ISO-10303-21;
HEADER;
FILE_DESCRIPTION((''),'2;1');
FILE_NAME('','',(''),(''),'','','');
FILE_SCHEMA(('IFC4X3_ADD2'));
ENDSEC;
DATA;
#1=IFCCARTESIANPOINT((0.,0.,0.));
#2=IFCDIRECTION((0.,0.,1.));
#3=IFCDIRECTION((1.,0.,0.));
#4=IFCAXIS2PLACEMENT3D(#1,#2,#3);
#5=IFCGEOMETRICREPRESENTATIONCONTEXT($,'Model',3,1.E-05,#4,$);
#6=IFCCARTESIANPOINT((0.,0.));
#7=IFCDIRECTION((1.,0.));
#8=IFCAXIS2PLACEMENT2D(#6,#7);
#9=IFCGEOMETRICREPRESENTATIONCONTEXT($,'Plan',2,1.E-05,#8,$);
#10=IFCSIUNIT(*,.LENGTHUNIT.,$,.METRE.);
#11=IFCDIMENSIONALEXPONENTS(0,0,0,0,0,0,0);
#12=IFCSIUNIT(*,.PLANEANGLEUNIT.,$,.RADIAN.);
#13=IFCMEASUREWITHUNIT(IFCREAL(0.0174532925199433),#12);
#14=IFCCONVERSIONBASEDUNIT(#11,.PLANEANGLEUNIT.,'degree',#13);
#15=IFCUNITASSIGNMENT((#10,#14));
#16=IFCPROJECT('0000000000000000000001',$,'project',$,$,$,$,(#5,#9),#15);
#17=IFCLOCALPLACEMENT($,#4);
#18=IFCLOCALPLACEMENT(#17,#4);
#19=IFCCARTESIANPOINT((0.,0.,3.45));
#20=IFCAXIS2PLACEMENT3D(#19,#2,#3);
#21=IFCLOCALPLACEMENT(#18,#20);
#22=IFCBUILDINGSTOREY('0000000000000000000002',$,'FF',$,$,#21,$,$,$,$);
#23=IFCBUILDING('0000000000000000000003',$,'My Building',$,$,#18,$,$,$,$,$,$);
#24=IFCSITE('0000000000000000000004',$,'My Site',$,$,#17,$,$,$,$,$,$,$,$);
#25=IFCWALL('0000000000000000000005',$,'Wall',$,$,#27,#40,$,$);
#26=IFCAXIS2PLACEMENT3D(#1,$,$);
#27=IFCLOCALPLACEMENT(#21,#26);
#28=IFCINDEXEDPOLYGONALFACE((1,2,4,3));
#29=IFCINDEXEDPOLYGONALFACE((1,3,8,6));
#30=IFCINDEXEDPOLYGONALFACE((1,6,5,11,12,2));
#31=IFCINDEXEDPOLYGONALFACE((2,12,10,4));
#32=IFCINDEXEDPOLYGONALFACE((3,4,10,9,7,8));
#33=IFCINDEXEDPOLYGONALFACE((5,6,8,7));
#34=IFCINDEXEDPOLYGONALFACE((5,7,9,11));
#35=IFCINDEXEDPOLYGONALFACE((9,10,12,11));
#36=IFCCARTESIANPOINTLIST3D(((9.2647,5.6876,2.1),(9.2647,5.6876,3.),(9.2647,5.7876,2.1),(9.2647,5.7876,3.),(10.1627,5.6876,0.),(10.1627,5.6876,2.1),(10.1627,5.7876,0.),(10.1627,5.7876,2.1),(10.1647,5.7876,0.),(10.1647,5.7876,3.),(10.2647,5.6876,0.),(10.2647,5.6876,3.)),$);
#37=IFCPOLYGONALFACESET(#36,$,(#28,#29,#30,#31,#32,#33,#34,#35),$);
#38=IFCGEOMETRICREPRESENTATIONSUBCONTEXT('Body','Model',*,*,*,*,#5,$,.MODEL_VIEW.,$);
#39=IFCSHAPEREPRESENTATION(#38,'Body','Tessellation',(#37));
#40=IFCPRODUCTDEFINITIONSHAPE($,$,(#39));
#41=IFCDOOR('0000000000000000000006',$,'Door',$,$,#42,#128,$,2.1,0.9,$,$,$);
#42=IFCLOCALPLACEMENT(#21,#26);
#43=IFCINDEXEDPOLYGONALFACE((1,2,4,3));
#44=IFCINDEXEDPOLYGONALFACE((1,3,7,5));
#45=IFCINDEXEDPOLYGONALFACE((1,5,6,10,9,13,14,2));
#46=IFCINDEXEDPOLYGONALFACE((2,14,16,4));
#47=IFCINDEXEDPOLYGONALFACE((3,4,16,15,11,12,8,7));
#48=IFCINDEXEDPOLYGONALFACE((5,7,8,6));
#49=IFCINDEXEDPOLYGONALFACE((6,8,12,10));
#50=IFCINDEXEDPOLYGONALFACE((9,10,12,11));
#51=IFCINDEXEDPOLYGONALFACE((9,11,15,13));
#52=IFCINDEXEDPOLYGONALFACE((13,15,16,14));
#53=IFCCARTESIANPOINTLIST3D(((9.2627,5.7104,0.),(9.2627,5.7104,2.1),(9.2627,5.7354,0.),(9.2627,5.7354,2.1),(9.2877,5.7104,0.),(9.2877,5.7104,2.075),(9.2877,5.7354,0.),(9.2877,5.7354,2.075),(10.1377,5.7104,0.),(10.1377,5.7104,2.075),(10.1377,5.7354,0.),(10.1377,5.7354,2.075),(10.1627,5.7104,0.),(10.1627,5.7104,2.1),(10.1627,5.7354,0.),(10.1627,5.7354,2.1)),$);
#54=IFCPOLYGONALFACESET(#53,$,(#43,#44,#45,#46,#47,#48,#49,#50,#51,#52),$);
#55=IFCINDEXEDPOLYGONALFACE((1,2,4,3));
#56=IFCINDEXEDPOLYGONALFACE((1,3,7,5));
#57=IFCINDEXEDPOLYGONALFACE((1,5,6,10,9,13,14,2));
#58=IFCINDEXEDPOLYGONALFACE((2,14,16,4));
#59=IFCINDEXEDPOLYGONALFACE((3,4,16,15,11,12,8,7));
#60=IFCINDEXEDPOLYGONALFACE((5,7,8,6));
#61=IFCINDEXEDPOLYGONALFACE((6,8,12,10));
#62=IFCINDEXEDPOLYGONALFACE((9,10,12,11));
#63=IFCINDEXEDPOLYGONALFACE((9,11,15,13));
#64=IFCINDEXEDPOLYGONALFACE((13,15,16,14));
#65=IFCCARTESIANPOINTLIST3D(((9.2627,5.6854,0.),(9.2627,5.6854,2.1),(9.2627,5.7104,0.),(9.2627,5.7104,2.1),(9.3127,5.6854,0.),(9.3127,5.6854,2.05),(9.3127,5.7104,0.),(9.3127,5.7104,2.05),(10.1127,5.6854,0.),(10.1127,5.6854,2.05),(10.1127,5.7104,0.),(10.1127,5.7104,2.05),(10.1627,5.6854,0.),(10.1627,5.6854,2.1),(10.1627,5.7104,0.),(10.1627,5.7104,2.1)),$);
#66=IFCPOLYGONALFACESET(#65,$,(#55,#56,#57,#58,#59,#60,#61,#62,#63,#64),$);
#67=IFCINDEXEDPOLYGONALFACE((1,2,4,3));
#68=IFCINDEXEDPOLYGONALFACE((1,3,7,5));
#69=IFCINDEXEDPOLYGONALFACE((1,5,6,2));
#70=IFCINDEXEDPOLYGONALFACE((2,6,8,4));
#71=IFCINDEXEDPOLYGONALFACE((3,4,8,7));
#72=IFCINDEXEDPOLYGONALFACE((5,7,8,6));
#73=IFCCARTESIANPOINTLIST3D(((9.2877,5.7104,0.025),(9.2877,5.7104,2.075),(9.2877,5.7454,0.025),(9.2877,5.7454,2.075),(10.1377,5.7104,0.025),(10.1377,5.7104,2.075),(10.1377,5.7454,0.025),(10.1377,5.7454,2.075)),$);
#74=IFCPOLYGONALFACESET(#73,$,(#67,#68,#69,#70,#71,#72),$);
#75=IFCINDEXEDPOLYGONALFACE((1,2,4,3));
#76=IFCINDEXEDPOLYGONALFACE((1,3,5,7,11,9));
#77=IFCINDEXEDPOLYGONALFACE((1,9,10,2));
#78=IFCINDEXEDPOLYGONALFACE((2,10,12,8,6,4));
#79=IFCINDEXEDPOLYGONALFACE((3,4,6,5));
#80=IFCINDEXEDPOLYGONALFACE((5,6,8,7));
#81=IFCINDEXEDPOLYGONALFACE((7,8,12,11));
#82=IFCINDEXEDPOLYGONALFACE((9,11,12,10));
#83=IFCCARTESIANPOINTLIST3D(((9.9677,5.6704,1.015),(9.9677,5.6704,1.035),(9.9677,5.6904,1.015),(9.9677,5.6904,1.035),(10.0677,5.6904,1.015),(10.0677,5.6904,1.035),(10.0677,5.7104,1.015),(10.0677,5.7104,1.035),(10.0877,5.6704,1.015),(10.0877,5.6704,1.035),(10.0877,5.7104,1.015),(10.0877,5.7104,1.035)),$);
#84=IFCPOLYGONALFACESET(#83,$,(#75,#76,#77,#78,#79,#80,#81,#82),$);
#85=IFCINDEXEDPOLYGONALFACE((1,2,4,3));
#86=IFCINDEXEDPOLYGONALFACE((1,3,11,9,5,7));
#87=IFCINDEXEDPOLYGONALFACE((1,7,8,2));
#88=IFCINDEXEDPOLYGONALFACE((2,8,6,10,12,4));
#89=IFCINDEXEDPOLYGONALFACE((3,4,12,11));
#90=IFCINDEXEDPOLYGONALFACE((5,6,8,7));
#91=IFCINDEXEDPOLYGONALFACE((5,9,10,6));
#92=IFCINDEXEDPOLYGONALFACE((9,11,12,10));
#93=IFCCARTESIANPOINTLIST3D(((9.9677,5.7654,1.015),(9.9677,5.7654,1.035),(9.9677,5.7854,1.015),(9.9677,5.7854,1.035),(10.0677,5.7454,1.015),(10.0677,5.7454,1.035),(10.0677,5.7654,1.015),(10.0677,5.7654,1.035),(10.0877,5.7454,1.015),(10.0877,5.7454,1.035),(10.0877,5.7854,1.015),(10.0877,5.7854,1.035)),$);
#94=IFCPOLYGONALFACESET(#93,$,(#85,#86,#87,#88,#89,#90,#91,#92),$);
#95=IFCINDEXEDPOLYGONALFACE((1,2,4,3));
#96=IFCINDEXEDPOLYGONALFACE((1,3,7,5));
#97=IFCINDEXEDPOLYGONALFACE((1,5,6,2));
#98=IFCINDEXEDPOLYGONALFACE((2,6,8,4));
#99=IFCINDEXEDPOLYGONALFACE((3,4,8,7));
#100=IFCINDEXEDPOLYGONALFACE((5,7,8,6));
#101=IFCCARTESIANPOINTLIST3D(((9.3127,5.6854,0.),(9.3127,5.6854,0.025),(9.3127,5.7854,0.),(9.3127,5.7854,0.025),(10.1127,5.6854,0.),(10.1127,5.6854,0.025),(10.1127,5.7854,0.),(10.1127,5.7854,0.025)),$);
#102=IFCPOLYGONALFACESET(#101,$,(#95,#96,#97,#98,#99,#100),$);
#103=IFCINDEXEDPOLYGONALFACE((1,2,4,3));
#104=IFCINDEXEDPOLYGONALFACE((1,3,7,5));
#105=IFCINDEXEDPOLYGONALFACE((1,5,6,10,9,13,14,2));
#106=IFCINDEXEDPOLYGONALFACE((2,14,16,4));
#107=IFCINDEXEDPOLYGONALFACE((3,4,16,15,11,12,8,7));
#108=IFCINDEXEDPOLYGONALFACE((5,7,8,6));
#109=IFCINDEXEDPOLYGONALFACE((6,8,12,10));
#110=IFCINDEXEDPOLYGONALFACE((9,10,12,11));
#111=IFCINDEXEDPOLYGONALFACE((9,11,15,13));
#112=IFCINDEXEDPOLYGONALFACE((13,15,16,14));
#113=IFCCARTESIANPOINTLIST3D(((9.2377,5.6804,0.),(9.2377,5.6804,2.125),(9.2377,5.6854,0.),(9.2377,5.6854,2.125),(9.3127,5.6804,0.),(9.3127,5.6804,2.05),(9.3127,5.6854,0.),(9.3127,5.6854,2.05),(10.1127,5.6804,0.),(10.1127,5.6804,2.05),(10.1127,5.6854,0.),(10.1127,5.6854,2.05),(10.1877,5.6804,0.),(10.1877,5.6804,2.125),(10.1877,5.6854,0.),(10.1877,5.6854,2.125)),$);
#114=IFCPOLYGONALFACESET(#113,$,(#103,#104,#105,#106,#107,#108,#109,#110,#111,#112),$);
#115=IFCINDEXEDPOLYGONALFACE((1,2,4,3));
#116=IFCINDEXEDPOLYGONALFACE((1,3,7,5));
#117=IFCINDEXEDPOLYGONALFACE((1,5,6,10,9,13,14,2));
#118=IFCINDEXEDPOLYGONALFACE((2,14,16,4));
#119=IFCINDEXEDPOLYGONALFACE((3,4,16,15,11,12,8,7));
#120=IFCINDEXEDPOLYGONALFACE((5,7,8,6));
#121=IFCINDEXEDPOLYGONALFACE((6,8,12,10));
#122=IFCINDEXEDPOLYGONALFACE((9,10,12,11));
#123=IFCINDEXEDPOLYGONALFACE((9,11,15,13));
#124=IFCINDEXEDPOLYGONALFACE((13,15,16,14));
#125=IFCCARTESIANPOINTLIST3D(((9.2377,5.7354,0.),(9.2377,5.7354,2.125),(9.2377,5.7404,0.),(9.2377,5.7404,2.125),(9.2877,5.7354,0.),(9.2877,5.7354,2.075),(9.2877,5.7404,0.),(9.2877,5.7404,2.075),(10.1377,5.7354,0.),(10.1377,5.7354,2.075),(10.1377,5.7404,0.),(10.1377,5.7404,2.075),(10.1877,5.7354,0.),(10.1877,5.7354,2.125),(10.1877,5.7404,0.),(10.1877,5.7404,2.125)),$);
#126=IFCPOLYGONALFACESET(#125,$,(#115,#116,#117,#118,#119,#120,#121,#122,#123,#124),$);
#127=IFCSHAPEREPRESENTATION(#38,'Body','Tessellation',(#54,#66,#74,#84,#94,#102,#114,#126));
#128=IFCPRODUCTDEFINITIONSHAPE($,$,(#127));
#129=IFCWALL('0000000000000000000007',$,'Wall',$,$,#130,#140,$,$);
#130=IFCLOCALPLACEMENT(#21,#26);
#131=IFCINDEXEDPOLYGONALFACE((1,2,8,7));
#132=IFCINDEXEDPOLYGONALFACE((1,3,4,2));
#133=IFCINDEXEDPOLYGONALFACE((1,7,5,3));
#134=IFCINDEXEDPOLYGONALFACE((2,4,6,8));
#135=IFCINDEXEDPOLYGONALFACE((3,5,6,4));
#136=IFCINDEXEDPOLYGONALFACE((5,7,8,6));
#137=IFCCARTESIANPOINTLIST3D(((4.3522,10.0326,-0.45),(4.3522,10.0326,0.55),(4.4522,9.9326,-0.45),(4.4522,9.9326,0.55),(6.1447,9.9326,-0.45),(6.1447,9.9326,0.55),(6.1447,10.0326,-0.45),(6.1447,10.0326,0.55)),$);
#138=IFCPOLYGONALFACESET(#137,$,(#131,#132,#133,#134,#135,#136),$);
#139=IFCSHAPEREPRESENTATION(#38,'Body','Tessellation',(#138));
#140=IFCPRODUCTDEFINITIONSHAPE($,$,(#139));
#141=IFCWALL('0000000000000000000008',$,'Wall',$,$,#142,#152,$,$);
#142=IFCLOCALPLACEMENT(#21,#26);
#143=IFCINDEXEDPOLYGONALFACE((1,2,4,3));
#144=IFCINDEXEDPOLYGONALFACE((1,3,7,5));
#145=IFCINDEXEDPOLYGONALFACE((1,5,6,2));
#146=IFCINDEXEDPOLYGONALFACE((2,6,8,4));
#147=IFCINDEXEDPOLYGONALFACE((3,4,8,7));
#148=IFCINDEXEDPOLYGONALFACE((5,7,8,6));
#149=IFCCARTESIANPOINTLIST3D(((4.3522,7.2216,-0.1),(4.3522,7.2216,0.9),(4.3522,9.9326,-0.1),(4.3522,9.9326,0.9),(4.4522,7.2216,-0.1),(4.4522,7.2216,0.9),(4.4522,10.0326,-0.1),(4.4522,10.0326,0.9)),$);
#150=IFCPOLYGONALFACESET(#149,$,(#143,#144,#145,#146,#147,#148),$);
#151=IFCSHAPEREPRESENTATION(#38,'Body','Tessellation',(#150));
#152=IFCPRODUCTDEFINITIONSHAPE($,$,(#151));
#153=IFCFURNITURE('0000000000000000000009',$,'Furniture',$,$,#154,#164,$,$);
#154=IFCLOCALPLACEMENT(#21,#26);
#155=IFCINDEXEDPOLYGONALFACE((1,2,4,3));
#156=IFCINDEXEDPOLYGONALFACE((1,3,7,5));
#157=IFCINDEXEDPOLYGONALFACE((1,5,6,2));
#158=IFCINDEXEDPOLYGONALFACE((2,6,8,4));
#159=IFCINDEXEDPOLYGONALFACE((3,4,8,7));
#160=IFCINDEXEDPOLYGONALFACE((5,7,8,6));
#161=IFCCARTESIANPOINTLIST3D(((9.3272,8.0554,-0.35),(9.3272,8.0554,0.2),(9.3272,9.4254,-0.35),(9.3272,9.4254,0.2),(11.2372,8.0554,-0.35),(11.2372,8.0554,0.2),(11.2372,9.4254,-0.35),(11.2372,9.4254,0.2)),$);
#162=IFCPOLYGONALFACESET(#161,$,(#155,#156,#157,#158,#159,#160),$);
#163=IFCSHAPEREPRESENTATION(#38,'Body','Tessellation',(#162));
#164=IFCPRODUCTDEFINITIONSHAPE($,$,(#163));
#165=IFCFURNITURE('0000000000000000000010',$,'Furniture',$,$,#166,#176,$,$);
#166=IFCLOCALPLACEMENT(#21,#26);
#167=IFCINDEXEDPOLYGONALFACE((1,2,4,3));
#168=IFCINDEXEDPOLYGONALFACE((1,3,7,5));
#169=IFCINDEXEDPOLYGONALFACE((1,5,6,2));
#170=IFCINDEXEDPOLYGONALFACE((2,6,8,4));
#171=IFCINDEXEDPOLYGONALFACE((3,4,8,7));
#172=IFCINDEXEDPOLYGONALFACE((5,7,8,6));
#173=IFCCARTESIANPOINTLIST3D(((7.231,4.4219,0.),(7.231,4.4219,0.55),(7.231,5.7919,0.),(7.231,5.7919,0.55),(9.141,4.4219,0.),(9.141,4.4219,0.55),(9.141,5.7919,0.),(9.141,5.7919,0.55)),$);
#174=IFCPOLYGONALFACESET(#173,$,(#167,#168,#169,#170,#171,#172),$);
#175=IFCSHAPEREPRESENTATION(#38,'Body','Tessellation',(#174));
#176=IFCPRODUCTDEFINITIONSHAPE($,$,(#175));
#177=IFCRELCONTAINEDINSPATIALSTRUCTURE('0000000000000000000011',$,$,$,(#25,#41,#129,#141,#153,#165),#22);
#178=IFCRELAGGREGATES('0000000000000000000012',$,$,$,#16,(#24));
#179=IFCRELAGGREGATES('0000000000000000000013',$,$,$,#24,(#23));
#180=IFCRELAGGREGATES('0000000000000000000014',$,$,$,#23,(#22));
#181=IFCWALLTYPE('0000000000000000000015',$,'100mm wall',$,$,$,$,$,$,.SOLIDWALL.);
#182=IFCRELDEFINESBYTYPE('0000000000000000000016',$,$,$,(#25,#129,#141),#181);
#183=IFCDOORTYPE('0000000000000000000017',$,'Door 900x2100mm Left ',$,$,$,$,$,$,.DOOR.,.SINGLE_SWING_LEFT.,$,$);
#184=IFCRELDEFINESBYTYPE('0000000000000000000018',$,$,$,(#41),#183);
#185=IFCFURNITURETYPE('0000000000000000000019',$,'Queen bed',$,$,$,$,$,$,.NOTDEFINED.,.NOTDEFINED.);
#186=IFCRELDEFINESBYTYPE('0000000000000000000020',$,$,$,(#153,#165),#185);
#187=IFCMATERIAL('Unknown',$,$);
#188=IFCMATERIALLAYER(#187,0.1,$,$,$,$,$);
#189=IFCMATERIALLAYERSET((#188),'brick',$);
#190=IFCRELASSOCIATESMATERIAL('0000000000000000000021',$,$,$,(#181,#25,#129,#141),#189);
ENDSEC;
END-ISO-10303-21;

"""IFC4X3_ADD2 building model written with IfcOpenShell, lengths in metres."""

from ifc_helpers import new_model, entity, si_unit, converted_unit, frame, origin_with_axes, origin_2d_with_axis, place, context, subcontext, project, spatial, line, indexed_curve, outline, extrude, shape, source, transform, mapped, material, layer, layer_set, layer_usage, type_object, type_shapes, element, fill, save


model = new_model("IFC4X3_ADD2")

# Units and contexts
model_context = context("Model", 3, precision=1e-05, world=origin_with_axes())
plan_context = context("Plan", 2, precision=1e-05, world=origin_2d_with_axis())
body_context_1 = subcontext(model_context, "Body", "Model", "MODEL_VIEW")
body_context_2 = subcontext(plan_context, "Body", "Plan", "PLAN_VIEW")
ifc_project = project(units=[si_unit("LENGTHUNIT", "METRE"), converted_unit("PLANEANGLEUNIT", "degree", entity("IfcReal", 0.0174532925199433), si_unit("PLANEANGLEUNIT", "RADIAN"), dimensions=[0, 0, 0, 0, 0, 0, 0])], contexts=[model_context, plan_context])

# Site, building, storey
site_placement = place(None, origin_with_axes())
site = spatial("IfcSite", under=ifc_project, at=site_placement, Name="My Site")
building_placement = place(site_placement, origin_with_axes())
building = spatial("IfcBuilding", under=site, at=building_placement, Name="My Building")
storey_placement = place(building_placement, frame((0.0, 0.0, 3.45), z_axis=(0.0, 0.0, 1.0), x_axis=(1.0, 0.0, 0.0)))
storey = spatial("IfcBuildingStorey", under=building, at=storey_placement, Name="FF")

# Shared definitions
ifc_material = material(Name="Unknown")

# Shared definitions
shared_shape_1 = source(origin_with_axes(), body_context_1, "Body", "SweptSolid", [
    extrude(outline(indexed_curve([(0.0, 0.0), (0.9, 0.0), (0.9, 2.1), (0.0, 2.1)], segments=[line(1, 2, 3, 4, 1)])), frame((0.0, -0.6, 0.0), z_axis=(0.0, -1.0, 0.0), x_axis=(1.0, 0.0, 0.0)), (0.0, 0.0, -1.0), 1.2),
])
door_type_1 = type_object("IfcDoorType", Name="Door 900x2100mm Left ", OperationType="SINGLE_SWING_LEFT", PredefinedType="DOOR")
shared_shape_2 = source(origin_with_axes(), body_context_1, "Body", "SweptSolid", [
    extrude(outline(indexed_curve([(0.0, 0.0), (0.0, 2.1), (0.9, 2.1), (0.9, 0.0), (0.875, 0.0), (0.875, 2.075), (0.025, 2.075), (0.025, 0.0)], segments=[line(1, 2, 3, 4, 5, 6, 7, 8, 1)])), frame((0.0, 0.025, 0.0), z_axis=(0.0, -1.0, 0.0), x_axis=(1.0, 0.0, 0.0)), (0.0, 0.0, -1.0), 0.025),
    extrude(outline(indexed_curve([(0.0, 0.0), (0.0, 2.1), (0.9, 2.1), (0.9, 0.0), (0.85, 0.0), (0.85, 2.05), (0.05, 2.05), (0.05, 0.0)], segments=[line(1, 2, 3, 4, 5, 6, 7, 8, 1)])), frame((0.0, 0.0, 0.0), z_axis=(0.0, -1.0, 0.0), x_axis=(1.0, 0.0, 0.0)), (0.0, 0.0, -1.0), 0.025),
    extrude(outline(indexed_curve([(0.0, 0.0), (0.85, 0.0), (0.85, 0.035), (0.0, 0.035)], segments=[line(1, 2, 3, 4, 1)])), frame((0.025, 0.025, 0.025), z_axis=(0.0, 0.0, 1.0), x_axis=(1.0, 0.0, 0.0)), (0.0, 0.0, 1.0), 2.05),
    extrude(outline(indexed_curve([(0.0, 0.0), (0.0, -0.04), (-0.12, -0.04), (-0.12, -0.02), (-0.02, -0.02), (-0.02, 0.0)], segments=[line(1, 2, 3, 4, 5, 6, 1)])), frame((0.825, 0.025, 1.015), z_axis=(0.0, 0.0, 1.0), x_axis=(1.0, 0.0, 0.0)), (0.0, 0.0, 1.0), 0.02),
    extrude(outline(indexed_curve([(0.0, 0.0), (0.0, 0.04), (-0.12, 0.04), (-0.12, 0.02), (-0.02, 0.02), (-0.02, 0.0)], segments=[line(1, 2, 3, 4, 5, 6, 1)])), frame((0.825, 0.06, 1.015), z_axis=(0.0, 0.0, 1.0), x_axis=(1.0, 0.0, 0.0)), (0.0, 0.0, 1.0), 0.02),
    extrude(outline(indexed_curve([(0.0, 0.0), (0.8, 0.0), (0.8, 0.1), (0.0, 0.1)], segments=[line(1, 2, 3, 4, 1)])), frame((0.05, 0.0, 0.0), z_axis=(0.0, 0.0, 1.0), x_axis=(1.0, 0.0, 0.0)), (0.0, 0.0, 1.0), 0.025),
    extrude(outline(indexed_curve([(0.0, 0.0), (0.0, 2.125), (0.95, 2.125), (0.95, 0.0), (0.875, 0.0), (0.875, 2.05), (0.075, 2.05), (0.075, 0.0)], segments=[line(1, 2, 3, 4, 5, 6, 7, 8, 1)])), frame((-0.025, -0.005, 0.0), z_axis=(0.0, -1.0, 0.0), x_axis=(1.0, 0.0, 0.0)), (0.0, 0.0, -1.0), 0.005),
    extrude(outline(indexed_curve([(0.0, 0.0), (0.0, 2.125), (0.95, 2.125), (0.95, 0.0), (0.9, 0.0), (0.9, 2.075), (0.05, 2.075), (0.05, 0.0)], segments=[line(1, 2, 3, 4, 5, 6, 7, 8, 1)])), frame((-0.025, 0.05, 0.0), z_axis=(0.0, -1.0, 0.0), x_axis=(1.0, 0.0, 0.0)), (0.0, 0.0, -1.0), 0.005),
])
shared_shape_3 = source(origin_with_axes(), body_context_2, "Body", "Curve2D", [
    entity("IfcIndexedPolyCurve", entity("IfcCartesianPointList2D", [[0.0, 0.0], [0.0, 0.05], [0.025, 0.05], [0.025, 0.025], [0.05, 0.025], [0.05, 0.0]]), [entity("IfcLineIndex", [1, 2, 3, 4, 5, 6, 1])]),
    entity("IfcIndexedPolyCurve", entity("IfcCartesianPointList2D", [[0.9, 0.0], [0.9, 0.05], [0.875, 0.05], [0.875, 0.025], [0.85, 0.025], [0.85, 0.0]]), [entity("IfcLineIndex", [1, 2, 3, 4, 5, 6, 1])]),
    entity("IfcTrimmedCurve", entity("IfcEllipse", entity("IfcAxis2Placement2D", entity("IfcCartesianPoint", [0.06, 0.05]), entity("IfcDirection", [1.0, 0.0])), 0.815, 0.85), [entity("IfcCartesianPoint", [0.875, 0.05])], [entity("IfcCartesianPoint", [0.06, 0.9])], True, "CARTESIAN"),
    entity("IfcIndexedPolyCurve", entity("IfcCartesianPointList2D", [[0.025, 0.05], [0.06, 0.05], [0.06, 0.9], [0.025, 0.9]]), [entity("IfcLineIndex", [1, 2, 3, 4, 1])]),
])
type_shapes(door_type_1, [shared_shape_2, shared_shape_3])
ifc_layer_1 = layer(ifc_material, 0.1)
ifc_layer_set_1 = layer_set([ifc_layer_1], Name="brick")
wall_type_1 = type_object("IfcWallType", Name="100mm wall", PredefinedType="SOLIDWALL", material=ifc_layer_set_1)

# Wall, opening, door
ifc_layer_usage_1 = layer_usage(ifc_layer_set_1, "AXIS2", "POSITIVE", 0.0)
wall_1_placement = place(storey_placement, frame((10.2647, 5.7876, 0.0), z_axis=(0.0, 0.0, 1.0), x_axis=(-1.0, 0.0, 0.0)))
wall_1 = element("IfcWall", 1, at=wall_1_placement, inside=storey, type_object=wall_type_1, material=ifc_layer_usage_1, Name="Wall", context=body_context_1, shape_type="SweptSolid", body=[
    extrude(outline(indexed_curve([(0.1, 0.0), (0.0, 0.1), (1.0, 0.1), (1.0, 0.0)], segments=[line(1, 2, 3, 4, 1)])), origin_with_axes(), (0.0, 0.0, 1.0), 3.0),
])
opening_1_placement = place(wall_1_placement, frame((1.002, 0.1022, 0.0), z_axis=(0.0, 0.0, 1.0), x_axis=(-1.0, 0.0, 0.0)))
opening_1 = element("IfcOpeningElement", 2, at=opening_1_placement, cuts=wall_1, PredefinedType="OPENING", context=body_context_1, shape_type="MappedRepresentation", body=[
    mapped(shared_shape_1, transform((0.0, 0.0, 0.0), x_axis=(1.0, 0.0, 0.0), y_axis=(0.0, 1.0, 0.0), z_axis=(0.0, 0.0, 1.0), scale=1.0)),
])
door_1_placement = place(opening_1_placement, frame((0.0, 0.0, 0.0), z_axis=(0.0, 0.0, 1.0), x_axis=(1.0, 0.0, 0.0)))
door_1 = element("IfcDoor", 3, at=door_1_placement, inside=storey, type_object=door_type_1, Name="Door", OverallHeight=2.1, OverallWidth=0.9, shapes=[
    shape(body_context_1, "Body", "MappedRepresentation", [mapped(shared_shape_2, transform((0.0, 0.0, 0.0), x_axis=(1.0, 0.0, 0.0), y_axis=(0.0, 1.0, 0.0), z_axis=(0.0, 0.0, 1.0), scale=1.0))]),
    shape(body_context_2, "Body", "MappedRepresentation", [mapped(shared_shape_3, transform((0.0, 0.0, 0.0), x_axis=(1.0, 0.0, 0.0), y_axis=(0.0, 1.0, 0.0), z_axis=(0.0, 0.0, 1.0), scale=1.0))]),
])
fill(opening_1, door_1)

# Walls
ifc_layer_usage_2 = layer_usage(ifc_layer_set_1, "AXIS2", "POSITIVE", 0.0)
wall_2_placement = place(storey_placement, frame((6.1447, 10.0326, -0.45), z_axis=(0.0, 0.0, 1.0), x_axis=(-1.0, 0.0, 0.0)))
element("IfcWall", 4, at=wall_2_placement, inside=storey, type_object=wall_type_1, material=ifc_layer_usage_2, Name="Wall", context=body_context_1, shape_type="SweptSolid", body=[
    extrude(outline(indexed_curve([(0.0, 0.0), (0.0, 0.1), (1.6925, 0.1), (1.7925, 0.0)], segments=[line(1, 2, 3, 4, 1)])), origin_with_axes(), (0.0, 0.0, 1.0), 1.0),
])
ifc_layer_usage_3 = layer_usage(ifc_layer_set_1, "AXIS2", "POSITIVE", 0.0)
wall_3_placement = place(storey_placement, frame((4.4522, 7.2216, -0.1), z_axis=(0.0, 0.0, 1.0), x_axis=(0.0, 1.0, 0.0)))
element("IfcWall", 5, at=wall_3_placement, inside=storey, type_object=wall_type_1, material=ifc_layer_usage_3, Name="Wall", context=body_context_1, shape_type="SweptSolid", body=[
    extrude(outline(indexed_curve([(0.0, 0.0), (0.0, 0.1), (2.711, 0.1), (2.811, 0.0)], segments=[line(1, 2, 3, 4, 1)])), origin_with_axes(), (0.0, 0.0, 1.0), 1.0),
])

# Furniture
furniture_type = type_object("IfcFurnitureType", Name="Queen bed", AssemblyPlace="NOTDEFINED", PredefinedType="NOTDEFINED")
shared_shape_4 = source(origin_with_axes(), body_context_1, "Body", "SweptSolid", [
    extrude(outline(indexed_curve([(0.0, 0.0), (1.37, 0.0), (1.37, 1.91), (0.0, 1.91), (0.0, 0.0)])), origin_with_axes(), (0.0, 0.0, 1.0), 0.55),
])
shared_shape_5 = source(origin_with_axes(), body_context_2, "Body", "Curve2D", [
    entity("IfcIndexedPolyCurve", entity("IfcCartesianPointList2D", [[0.0, 1.5515], [0.0, 1.91], [1.37, 1.91], [1.37, 1.5515], [1.37, 0.0], [0.0, 0.0], [0.0, 1.5515], [1.37, 1.5515]])),
])
type_shapes(furniture_type, [shared_shape_4, shared_shape_5])
for number, where, z_axis, x_axis, name in (
    (6, (9.3272, 9.4254, -0.35), (0.0, 0.0, 1.0), (0.0, -1.0, 0.0), "Furniture"),
    (7, (7.231, 5.7919, 0.0), (0.0, 0.0, 1.0), (0.0, -1.0, 0.0), "Furniture"),
):
    element("IfcFurniture", number, at=place(storey_placement, frame(where, z_axis=z_axis, x_axis=x_axis)), inside=storey, type_object=furniture_type, Name=name, shapes=[
        shape(body_context_1, "Body", "MappedRepresentation", [mapped(shared_shape_4, transform((0.0, 0.0, 0.0), x_axis=(1.0, 0.0, 0.0), y_axis=(0.0, 1.0, 0.0), z_axis=(0.0, 0.0, 1.0), scale=1.0))]),
        shape(body_context_2, "Body", "MappedRepresentation", [mapped(shared_shape_5, transform((0.0, 0.0, 0.0), x_axis=(1.0, 0.0, 0.0), y_axis=(0.0, 1.0, 0.0), z_axis=(0.0, 0.0, 1.0), scale=1.0))]),
    ])

save(model, "model.ifc")
